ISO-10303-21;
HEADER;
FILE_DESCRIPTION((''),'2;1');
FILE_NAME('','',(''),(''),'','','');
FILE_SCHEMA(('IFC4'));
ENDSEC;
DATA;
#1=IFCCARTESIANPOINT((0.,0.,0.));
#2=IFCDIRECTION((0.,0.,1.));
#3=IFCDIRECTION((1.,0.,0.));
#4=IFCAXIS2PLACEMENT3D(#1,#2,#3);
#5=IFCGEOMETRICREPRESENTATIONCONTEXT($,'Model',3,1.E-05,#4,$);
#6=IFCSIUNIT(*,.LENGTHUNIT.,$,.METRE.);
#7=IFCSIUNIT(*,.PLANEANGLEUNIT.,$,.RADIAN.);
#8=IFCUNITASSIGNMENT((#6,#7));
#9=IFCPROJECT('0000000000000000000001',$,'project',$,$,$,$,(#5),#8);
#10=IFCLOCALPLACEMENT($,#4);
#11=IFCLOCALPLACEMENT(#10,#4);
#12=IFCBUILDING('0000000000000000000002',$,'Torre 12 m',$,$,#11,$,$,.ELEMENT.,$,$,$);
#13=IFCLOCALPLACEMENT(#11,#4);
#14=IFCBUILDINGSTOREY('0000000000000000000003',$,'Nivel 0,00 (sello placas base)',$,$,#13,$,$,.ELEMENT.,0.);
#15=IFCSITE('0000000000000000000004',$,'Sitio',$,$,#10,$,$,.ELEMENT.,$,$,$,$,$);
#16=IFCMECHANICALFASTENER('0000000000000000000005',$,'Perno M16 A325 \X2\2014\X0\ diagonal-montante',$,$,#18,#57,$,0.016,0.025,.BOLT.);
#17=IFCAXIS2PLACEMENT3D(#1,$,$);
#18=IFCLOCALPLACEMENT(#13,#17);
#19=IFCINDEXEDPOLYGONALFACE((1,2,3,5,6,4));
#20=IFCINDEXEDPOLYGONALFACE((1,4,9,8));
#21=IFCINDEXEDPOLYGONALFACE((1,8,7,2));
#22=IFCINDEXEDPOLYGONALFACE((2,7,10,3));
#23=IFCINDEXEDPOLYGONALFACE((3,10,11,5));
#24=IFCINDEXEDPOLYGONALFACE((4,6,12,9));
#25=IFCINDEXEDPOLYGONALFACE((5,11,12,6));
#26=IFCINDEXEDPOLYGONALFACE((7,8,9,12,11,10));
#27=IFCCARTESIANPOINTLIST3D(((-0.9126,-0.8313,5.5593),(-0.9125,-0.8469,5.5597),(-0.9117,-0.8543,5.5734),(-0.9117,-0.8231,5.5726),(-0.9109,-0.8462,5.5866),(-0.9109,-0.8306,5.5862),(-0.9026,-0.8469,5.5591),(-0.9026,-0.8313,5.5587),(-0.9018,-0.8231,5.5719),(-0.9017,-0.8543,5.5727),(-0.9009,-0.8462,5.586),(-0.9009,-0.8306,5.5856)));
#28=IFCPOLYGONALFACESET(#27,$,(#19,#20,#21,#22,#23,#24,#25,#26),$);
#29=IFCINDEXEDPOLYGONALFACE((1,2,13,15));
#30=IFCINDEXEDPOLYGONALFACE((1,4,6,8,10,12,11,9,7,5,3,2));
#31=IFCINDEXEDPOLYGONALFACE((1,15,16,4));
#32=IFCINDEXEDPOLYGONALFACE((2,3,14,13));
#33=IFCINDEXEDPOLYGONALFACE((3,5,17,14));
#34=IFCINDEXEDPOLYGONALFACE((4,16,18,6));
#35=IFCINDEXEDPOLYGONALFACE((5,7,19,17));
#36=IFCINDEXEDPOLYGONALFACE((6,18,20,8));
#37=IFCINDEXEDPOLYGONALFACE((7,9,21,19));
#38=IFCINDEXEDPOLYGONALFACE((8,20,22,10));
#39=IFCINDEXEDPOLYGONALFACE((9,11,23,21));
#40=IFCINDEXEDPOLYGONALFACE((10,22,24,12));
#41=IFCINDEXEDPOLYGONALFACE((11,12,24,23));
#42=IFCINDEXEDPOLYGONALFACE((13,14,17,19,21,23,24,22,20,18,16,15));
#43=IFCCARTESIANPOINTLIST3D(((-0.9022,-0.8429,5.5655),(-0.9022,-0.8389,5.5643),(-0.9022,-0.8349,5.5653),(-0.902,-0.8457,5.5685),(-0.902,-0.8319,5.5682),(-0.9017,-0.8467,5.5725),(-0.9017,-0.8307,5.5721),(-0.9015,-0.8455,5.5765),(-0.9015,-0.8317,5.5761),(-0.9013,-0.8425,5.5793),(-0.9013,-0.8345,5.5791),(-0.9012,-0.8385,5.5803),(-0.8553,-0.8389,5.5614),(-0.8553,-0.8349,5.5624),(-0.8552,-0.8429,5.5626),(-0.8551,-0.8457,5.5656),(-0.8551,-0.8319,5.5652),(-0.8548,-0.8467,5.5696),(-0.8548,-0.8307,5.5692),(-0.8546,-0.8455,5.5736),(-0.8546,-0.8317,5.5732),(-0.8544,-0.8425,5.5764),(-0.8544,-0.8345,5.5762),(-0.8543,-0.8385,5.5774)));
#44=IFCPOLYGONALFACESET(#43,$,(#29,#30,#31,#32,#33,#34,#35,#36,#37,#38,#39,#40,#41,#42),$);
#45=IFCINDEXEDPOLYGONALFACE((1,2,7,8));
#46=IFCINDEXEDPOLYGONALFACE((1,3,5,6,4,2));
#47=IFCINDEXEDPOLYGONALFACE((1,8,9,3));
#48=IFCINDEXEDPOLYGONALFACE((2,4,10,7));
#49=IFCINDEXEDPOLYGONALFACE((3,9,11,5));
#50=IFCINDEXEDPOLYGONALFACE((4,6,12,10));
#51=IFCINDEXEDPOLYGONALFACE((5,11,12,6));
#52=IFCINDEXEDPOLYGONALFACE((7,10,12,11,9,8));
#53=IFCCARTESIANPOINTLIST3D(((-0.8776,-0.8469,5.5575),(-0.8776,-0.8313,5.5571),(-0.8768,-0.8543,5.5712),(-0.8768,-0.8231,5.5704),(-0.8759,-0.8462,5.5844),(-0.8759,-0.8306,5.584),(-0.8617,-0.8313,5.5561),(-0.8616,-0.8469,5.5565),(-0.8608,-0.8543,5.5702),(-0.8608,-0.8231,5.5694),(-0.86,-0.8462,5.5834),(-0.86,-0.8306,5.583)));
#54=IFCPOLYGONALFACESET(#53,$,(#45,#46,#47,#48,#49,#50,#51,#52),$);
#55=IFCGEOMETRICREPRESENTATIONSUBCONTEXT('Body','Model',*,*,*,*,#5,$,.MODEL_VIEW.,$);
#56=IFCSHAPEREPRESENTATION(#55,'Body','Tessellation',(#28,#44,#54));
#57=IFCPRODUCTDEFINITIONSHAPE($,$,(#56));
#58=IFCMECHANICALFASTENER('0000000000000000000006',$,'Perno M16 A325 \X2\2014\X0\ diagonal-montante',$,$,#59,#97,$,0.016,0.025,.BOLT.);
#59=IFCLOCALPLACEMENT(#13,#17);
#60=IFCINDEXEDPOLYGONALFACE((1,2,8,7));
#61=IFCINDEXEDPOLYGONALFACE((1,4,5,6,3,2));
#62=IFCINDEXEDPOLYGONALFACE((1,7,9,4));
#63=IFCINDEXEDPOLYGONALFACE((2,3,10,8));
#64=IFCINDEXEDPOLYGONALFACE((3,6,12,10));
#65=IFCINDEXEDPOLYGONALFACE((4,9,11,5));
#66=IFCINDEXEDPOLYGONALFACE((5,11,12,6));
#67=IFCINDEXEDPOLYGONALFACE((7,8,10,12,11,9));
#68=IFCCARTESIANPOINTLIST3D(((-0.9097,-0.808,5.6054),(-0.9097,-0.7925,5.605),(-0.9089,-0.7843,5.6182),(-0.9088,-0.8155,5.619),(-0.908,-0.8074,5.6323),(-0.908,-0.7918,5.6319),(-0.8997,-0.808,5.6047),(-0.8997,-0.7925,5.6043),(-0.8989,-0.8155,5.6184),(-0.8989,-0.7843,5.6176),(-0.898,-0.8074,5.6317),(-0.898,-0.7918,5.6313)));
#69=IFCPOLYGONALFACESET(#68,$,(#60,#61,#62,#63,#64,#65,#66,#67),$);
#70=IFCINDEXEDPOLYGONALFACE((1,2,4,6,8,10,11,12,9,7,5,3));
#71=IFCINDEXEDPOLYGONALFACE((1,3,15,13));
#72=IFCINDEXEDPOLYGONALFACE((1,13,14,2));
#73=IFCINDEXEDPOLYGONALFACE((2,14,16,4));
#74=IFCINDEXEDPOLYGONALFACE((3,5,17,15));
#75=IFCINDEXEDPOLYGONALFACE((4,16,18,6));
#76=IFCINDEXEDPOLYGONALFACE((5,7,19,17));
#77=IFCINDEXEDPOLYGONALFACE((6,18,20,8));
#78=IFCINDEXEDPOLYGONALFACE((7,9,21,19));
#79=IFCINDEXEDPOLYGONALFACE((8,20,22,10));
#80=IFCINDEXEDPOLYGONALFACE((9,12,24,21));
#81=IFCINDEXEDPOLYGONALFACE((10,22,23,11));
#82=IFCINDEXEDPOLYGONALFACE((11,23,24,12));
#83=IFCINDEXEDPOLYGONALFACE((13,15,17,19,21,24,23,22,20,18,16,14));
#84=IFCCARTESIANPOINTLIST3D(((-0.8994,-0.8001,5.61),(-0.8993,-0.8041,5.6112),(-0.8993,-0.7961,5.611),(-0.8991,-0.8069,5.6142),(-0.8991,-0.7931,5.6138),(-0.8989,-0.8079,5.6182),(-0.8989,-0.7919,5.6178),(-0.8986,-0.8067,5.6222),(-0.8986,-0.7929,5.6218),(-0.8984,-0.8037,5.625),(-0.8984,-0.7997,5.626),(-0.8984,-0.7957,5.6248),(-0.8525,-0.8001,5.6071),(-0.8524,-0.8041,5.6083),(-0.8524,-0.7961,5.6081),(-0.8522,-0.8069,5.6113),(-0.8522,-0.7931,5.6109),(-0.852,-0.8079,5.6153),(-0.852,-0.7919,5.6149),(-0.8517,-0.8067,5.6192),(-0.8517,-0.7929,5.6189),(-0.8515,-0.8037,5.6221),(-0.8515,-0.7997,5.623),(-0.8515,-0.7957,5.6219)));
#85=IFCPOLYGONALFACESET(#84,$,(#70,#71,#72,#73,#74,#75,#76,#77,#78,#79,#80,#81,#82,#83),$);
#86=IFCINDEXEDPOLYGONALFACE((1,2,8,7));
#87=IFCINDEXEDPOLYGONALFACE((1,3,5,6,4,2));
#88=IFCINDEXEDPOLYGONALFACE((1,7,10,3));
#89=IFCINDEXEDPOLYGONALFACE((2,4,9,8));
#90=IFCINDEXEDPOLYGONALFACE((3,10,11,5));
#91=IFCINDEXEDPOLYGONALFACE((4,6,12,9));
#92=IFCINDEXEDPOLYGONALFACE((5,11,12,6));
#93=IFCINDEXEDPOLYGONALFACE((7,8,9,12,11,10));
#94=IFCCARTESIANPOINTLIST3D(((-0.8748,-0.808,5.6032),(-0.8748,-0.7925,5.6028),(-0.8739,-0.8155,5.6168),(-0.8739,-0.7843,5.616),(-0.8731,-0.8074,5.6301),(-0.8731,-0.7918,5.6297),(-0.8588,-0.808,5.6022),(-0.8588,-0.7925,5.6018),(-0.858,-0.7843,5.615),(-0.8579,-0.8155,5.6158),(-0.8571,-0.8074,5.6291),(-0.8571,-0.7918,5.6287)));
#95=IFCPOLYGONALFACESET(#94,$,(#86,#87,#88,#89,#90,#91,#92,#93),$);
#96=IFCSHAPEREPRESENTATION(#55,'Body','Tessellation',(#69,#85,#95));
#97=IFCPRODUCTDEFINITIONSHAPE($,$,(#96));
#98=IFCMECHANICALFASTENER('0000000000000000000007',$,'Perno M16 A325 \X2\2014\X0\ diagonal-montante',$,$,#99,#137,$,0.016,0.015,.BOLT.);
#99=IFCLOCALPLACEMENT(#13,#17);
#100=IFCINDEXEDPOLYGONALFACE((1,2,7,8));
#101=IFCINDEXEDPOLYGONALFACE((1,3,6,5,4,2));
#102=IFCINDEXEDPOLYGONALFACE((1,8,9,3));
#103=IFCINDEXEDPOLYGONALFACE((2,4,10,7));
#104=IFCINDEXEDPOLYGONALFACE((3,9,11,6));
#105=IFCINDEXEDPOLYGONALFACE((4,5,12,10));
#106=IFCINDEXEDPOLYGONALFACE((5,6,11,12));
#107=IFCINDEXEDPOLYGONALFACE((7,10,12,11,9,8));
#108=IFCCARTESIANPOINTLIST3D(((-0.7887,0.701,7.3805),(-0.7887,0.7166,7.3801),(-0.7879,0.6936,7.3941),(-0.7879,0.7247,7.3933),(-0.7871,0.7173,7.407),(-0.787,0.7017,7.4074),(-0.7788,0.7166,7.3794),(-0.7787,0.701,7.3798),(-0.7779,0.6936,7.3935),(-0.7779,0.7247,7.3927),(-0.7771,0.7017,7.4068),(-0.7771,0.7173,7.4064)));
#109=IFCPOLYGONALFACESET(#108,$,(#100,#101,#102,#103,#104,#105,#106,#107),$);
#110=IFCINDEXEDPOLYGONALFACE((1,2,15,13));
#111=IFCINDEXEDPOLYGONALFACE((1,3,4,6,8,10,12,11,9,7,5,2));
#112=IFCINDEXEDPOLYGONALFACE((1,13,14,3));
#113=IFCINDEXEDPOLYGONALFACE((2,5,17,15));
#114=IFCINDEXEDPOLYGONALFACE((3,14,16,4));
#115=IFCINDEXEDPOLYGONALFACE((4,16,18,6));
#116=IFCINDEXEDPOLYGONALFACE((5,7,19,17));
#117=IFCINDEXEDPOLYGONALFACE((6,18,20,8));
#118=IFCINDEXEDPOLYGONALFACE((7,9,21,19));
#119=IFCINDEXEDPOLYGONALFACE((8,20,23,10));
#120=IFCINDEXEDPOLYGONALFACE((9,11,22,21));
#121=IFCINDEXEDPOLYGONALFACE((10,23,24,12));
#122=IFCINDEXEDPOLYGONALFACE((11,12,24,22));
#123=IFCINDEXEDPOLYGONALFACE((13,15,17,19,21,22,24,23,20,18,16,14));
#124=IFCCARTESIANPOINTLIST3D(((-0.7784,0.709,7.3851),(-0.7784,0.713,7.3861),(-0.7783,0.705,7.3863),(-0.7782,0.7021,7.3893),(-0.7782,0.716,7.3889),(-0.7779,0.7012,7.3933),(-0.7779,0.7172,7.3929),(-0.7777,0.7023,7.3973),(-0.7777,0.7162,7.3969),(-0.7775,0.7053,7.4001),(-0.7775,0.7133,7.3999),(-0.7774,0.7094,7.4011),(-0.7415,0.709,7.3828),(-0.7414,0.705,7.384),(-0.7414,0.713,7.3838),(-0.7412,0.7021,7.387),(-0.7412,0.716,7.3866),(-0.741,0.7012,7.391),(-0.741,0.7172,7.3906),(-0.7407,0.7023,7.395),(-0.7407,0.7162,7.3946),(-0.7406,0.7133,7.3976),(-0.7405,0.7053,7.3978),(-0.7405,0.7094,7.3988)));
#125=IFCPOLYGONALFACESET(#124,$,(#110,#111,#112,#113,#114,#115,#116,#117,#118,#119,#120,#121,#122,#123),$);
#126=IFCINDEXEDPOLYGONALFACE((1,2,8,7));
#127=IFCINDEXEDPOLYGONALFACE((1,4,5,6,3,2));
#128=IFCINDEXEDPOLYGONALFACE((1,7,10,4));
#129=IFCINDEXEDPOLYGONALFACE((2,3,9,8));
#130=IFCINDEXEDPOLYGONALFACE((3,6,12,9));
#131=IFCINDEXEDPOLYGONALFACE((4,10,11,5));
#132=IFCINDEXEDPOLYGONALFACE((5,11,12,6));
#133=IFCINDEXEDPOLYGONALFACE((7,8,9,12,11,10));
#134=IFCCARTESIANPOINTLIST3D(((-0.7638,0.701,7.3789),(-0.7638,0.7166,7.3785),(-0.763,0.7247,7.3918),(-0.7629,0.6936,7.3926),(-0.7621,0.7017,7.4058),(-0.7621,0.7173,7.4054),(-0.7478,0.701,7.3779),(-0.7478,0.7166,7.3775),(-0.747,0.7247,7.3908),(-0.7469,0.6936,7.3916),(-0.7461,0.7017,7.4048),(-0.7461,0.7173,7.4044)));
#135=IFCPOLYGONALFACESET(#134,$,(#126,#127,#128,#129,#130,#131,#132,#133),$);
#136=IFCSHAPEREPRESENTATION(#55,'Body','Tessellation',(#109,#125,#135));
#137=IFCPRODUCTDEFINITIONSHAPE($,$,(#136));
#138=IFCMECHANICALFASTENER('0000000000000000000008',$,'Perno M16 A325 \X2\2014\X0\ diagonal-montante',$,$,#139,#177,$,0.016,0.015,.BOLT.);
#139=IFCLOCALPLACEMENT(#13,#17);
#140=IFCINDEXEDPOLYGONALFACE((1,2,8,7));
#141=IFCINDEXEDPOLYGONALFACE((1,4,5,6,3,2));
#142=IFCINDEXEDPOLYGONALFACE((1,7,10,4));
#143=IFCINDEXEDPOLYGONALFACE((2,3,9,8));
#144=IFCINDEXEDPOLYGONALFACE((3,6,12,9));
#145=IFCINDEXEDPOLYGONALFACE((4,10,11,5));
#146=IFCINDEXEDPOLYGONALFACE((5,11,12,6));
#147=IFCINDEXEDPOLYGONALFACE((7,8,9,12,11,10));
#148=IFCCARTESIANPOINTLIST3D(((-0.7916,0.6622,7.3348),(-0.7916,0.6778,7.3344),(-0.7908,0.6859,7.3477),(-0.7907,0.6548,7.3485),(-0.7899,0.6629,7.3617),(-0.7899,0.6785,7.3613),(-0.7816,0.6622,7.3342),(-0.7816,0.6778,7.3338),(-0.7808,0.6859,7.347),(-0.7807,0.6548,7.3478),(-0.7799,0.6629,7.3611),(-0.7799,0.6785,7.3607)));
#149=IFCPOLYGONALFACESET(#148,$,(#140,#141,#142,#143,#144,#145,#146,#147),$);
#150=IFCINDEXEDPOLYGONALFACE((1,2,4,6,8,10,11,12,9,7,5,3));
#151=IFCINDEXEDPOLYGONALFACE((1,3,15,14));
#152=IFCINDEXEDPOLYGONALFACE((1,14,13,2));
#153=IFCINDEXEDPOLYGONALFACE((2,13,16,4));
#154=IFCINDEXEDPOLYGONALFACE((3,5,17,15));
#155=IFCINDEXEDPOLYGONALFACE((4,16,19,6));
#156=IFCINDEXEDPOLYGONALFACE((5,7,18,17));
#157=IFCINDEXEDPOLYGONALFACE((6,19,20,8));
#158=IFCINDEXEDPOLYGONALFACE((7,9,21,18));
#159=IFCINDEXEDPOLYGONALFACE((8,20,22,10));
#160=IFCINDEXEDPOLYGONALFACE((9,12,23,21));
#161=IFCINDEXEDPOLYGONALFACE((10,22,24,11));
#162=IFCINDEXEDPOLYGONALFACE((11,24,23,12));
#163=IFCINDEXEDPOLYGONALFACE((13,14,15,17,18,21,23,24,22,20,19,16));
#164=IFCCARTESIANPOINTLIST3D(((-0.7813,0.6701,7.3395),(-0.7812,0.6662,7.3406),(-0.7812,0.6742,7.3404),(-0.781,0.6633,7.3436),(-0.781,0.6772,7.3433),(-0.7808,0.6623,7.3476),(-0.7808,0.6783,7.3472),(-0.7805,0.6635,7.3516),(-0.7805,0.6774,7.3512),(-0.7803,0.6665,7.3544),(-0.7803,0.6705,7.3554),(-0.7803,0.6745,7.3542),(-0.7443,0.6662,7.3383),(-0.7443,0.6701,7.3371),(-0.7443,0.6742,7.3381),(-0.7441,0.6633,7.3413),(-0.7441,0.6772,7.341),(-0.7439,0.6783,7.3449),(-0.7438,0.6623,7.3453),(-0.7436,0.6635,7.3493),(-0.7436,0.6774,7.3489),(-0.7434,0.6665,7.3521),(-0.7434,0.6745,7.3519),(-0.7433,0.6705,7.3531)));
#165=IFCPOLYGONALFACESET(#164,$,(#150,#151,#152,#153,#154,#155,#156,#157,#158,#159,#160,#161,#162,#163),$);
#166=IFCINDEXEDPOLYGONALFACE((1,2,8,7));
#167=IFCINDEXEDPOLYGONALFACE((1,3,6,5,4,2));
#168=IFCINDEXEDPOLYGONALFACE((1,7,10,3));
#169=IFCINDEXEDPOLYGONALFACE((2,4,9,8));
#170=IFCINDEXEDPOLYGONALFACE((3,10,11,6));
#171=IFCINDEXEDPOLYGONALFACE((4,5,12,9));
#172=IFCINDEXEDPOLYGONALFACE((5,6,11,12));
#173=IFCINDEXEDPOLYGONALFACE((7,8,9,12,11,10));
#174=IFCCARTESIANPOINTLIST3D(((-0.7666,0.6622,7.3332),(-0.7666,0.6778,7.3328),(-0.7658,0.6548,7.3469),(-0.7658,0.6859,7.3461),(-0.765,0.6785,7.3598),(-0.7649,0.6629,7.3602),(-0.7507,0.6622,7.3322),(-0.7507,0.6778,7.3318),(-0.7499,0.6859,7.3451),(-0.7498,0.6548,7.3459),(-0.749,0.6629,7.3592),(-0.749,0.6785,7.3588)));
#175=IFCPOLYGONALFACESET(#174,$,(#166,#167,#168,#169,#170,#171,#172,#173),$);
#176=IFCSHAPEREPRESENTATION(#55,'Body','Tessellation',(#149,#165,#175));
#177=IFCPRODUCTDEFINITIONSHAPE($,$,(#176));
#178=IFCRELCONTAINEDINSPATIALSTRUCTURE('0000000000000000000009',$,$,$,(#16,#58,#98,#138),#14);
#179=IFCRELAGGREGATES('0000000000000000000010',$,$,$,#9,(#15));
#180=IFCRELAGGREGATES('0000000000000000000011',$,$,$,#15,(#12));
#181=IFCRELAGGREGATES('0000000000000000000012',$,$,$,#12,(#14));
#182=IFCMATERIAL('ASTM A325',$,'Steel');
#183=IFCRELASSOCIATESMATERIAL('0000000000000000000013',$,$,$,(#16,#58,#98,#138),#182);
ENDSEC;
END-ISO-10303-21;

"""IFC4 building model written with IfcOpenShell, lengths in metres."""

from ifc_helpers import new_model, si_unit, frame, origin_with_axes, place, context, subcontext, project, spatial, polyline, outline, extrude, material, element, save


model = new_model("IFC4")

# Units and contexts
model_context = context("Model", 3, precision=1e-05, world=origin_with_axes())
body_context = subcontext(model_context, "Body", "Model", "MODEL_VIEW")
ifc_project = project(units=[si_unit("LENGTHUNIT", "METRE"), si_unit("PLANEANGLEUNIT", "RADIAN")], contexts=[model_context])

# Site, building, storey
site_placement = place(None, origin_with_axes())
site = spatial("IfcSite", under=ifc_project, at=site_placement, Name="Sitio", CompositionType="ELEMENT")
building_placement = place(site_placement, origin_with_axes())
building = spatial("IfcBuilding", under=site, at=building_placement, Name="Torre 12 m", CompositionType="ELEMENT")
storey_placement = place(building_placement, origin_with_axes())
storey = spatial("IfcBuildingStorey", under=building, at=storey_placement, Name="Nivel 0,00 (sello placas base)", CompositionType="ELEMENT", Elevation=0.0)

# Shared definitions
placement = place(storey_placement, origin_with_axes())

# Mechanical fasteners
ifc_material_1 = material(Name="ASTM A325", Category="Steel")
element("IfcMechanicalFastener", 1, at=placement, inside=storey, material=ifc_material_1, Name="Perno M16 A325 — diagonal-montante", NominalDiameter=0.016, NominalLength=0.025, PredefinedType="BOLT", context=body_context, shape_type="SweptSolid", body=[
    extrude(outline(polyline([(0.0135, 0.0078), (0.0, 0.0156), (-0.0135, 0.0078), (-0.0135, -0.0078), (0.0, -0.0156), (0.0135, -0.0078), (0.0135, 0.0078)])), frame((-0.9117, -0.8387, 5.573), z_axis=(0.998053, 0.0, -0.062378), x_axis=(0.032557, -0.85299, 0.52091)), (0.0, 0.0, 1.0), 0.01),
    extrude(outline(polyline([(0.008, 0.0), (0.0069, 0.004), (0.004, 0.0069), (0.0, 0.008), (-0.004, 0.0069), (-0.0069, 0.004), (-0.008, 0.0), (-0.0069, -0.004), (-0.004, -0.0069), (0.0, -0.008), (0.004, -0.0069), (0.0069, -0.004), (0.008, 0.0)])), frame((-0.9017, -0.8387, 5.5723), z_axis=(0.998053, 0.0, -0.062378), x_axis=(0.032557, -0.85299, 0.52091)), (0.0, 0.0, 1.0), 0.047),
    extrude(outline(polyline([(0.0135, 0.0078), (0.0, 0.0156), (-0.0135, 0.0078), (-0.0135, -0.0078), (0.0, -0.0156), (0.0135, -0.0078), (0.0135, 0.0078)])), frame((-0.8768, -0.8387, 5.5708), z_axis=(0.998053, 0.0, -0.062378), x_axis=(0.032557, -0.85299, 0.52091)), (0.0, 0.0, 1.0), 0.016),
])
element("IfcMechanicalFastener", 2, at=placement, inside=storey, material=ifc_material_1, Name="Perno M16 A325 — diagonal-montante", NominalDiameter=0.016, NominalLength=0.025, PredefinedType="BOLT", context=body_context, shape_type="SweptSolid", body=[
    extrude(outline(polyline([(0.0135, 0.0078), (0.0, 0.0156), (-0.0135, 0.0078), (-0.0135, -0.0078), (0.0, -0.0156), (0.0135, -0.0078), (0.0135, 0.0078)])), frame((-0.9089, -0.7999, 5.6186), z_axis=(0.998053, 0.0, -0.062378), x_axis=(0.032557, -0.85299, 0.52091)), (0.0, 0.0, 1.0), 0.01),
    extrude(outline(polyline([(0.008, 0.0), (0.0069, 0.004), (0.004, 0.0069), (0.0, 0.008), (-0.004, 0.0069), (-0.0069, 0.004), (-0.008, 0.0), (-0.0069, -0.004), (-0.004, -0.0069), (0.0, -0.008), (0.004, -0.0069), (0.0069, -0.004), (0.008, 0.0)])), frame((-0.8989, -0.7999, 5.618), z_axis=(0.998053, 0.0, -0.062378), x_axis=(0.032557, -0.85299, 0.52091)), (0.0, 0.0, 1.0), 0.047),
    extrude(outline(polyline([(0.0135, 0.0078), (0.0, 0.0156), (-0.0135, 0.0078), (-0.0135, -0.0078), (0.0, -0.0156), (0.0135, -0.0078), (0.0135, 0.0078)])), frame((-0.8739, -0.7999, 5.6164), z_axis=(0.998053, 0.0, -0.062378), x_axis=(0.032557, -0.85299, 0.52091)), (0.0, 0.0, 1.0), 0.016),
])
element("IfcMechanicalFastener", 3, at=placement, inside=storey, material=ifc_material_1, Name="Perno M16 A325 — diagonal-montante", NominalDiameter=0.016, NominalLength=0.015, PredefinedType="BOLT", context=body_context, shape_type="SweptSolid", body=[
    extrude(outline(polyline([(0.0135, 0.0078), (0.0, 0.0156), (-0.0135, 0.0078), (-0.0135, -0.0078), (0.0, -0.0156), (0.0135, -0.0078), (0.0135, 0.0078)])), frame((-0.7879, 0.7092, 7.3937), z_axis=(0.998053, 0.0, -0.062378), x_axis=(0.032557, -0.85299, 0.52091)), (0.0, 0.0, 1.0), 0.01),
    extrude(outline(polyline([(0.008, 0.0), (0.0069, 0.004), (0.004, 0.0069), (0.0, 0.008), (-0.004, 0.0069), (-0.0069, 0.004), (-0.008, 0.0), (-0.0069, -0.004), (-0.004, -0.0069), (0.0, -0.008), (0.004, -0.0069), (0.0069, -0.004), (0.008, 0.0)])), frame((-0.7779, 0.7092, 7.3931), z_axis=(0.998053, 0.0, -0.062378), x_axis=(0.032557, -0.85299, 0.52091)), (0.0, 0.0, 1.0), 0.037),
    extrude(outline(polyline([(0.0135, 0.0078), (0.0, 0.0156), (-0.0135, 0.0078), (-0.0135, -0.0078), (0.0, -0.0156), (0.0135, -0.0078), (0.0135, 0.0078)])), frame((-0.7629, 0.7092, 7.3922), z_axis=(0.998053, 0.0, -0.062378), x_axis=(0.032557, -0.85299, 0.52091)), (0.0, 0.0, 1.0), 0.016),
])
element("IfcMechanicalFastener", 4, at=placement, inside=storey, material=ifc_material_1, Name="Perno M16 A325 — diagonal-montante", NominalDiameter=0.016, NominalLength=0.015, PredefinedType="BOLT", context=body_context, shape_type="SweptSolid", body=[
    extrude(outline(polyline([(0.0135, 0.0078), (0.0, 0.0156), (-0.0135, 0.0078), (-0.0135, -0.0078), (0.0, -0.0156), (0.0135, -0.0078), (0.0135, 0.0078)])), frame((-0.7907, 0.6703, 7.3481), z_axis=(0.998053, 0.0, -0.062378), x_axis=(0.032557, -0.85299, 0.52091)), (0.0, 0.0, 1.0), 0.01),
    extrude(outline(polyline([(0.008, 0.0), (0.0069, 0.004), (0.004, 0.0069), (0.0, 0.008), (-0.004, 0.0069), (-0.0069, 0.004), (-0.008, 0.0), (-0.0069, -0.004), (-0.004, -0.0069), (0.0, -0.008), (0.004, -0.0069), (0.0069, -0.004), (0.008, 0.0)])), frame((-0.7808, 0.6703, 7.3474), z_axis=(0.998053, 0.0, -0.062378), x_axis=(0.032557, -0.85299, 0.52091)), (0.0, 0.0, 1.0), 0.037),
    extrude(outline(polyline([(0.0135, 0.0078), (0.0, 0.0156), (-0.0135, 0.0078), (-0.0135, -0.0078), (0.0, -0.0156), (0.0135, -0.0078), (0.0135, 0.0078)])), frame((-0.7658, 0.6703, 7.3465), z_axis=(0.998053, 0.0, -0.062378), x_axis=(0.032557, -0.85299, 0.52091)), (0.0, 0.0, 1.0), 0.016),
])

save(model, "model.ifc")
